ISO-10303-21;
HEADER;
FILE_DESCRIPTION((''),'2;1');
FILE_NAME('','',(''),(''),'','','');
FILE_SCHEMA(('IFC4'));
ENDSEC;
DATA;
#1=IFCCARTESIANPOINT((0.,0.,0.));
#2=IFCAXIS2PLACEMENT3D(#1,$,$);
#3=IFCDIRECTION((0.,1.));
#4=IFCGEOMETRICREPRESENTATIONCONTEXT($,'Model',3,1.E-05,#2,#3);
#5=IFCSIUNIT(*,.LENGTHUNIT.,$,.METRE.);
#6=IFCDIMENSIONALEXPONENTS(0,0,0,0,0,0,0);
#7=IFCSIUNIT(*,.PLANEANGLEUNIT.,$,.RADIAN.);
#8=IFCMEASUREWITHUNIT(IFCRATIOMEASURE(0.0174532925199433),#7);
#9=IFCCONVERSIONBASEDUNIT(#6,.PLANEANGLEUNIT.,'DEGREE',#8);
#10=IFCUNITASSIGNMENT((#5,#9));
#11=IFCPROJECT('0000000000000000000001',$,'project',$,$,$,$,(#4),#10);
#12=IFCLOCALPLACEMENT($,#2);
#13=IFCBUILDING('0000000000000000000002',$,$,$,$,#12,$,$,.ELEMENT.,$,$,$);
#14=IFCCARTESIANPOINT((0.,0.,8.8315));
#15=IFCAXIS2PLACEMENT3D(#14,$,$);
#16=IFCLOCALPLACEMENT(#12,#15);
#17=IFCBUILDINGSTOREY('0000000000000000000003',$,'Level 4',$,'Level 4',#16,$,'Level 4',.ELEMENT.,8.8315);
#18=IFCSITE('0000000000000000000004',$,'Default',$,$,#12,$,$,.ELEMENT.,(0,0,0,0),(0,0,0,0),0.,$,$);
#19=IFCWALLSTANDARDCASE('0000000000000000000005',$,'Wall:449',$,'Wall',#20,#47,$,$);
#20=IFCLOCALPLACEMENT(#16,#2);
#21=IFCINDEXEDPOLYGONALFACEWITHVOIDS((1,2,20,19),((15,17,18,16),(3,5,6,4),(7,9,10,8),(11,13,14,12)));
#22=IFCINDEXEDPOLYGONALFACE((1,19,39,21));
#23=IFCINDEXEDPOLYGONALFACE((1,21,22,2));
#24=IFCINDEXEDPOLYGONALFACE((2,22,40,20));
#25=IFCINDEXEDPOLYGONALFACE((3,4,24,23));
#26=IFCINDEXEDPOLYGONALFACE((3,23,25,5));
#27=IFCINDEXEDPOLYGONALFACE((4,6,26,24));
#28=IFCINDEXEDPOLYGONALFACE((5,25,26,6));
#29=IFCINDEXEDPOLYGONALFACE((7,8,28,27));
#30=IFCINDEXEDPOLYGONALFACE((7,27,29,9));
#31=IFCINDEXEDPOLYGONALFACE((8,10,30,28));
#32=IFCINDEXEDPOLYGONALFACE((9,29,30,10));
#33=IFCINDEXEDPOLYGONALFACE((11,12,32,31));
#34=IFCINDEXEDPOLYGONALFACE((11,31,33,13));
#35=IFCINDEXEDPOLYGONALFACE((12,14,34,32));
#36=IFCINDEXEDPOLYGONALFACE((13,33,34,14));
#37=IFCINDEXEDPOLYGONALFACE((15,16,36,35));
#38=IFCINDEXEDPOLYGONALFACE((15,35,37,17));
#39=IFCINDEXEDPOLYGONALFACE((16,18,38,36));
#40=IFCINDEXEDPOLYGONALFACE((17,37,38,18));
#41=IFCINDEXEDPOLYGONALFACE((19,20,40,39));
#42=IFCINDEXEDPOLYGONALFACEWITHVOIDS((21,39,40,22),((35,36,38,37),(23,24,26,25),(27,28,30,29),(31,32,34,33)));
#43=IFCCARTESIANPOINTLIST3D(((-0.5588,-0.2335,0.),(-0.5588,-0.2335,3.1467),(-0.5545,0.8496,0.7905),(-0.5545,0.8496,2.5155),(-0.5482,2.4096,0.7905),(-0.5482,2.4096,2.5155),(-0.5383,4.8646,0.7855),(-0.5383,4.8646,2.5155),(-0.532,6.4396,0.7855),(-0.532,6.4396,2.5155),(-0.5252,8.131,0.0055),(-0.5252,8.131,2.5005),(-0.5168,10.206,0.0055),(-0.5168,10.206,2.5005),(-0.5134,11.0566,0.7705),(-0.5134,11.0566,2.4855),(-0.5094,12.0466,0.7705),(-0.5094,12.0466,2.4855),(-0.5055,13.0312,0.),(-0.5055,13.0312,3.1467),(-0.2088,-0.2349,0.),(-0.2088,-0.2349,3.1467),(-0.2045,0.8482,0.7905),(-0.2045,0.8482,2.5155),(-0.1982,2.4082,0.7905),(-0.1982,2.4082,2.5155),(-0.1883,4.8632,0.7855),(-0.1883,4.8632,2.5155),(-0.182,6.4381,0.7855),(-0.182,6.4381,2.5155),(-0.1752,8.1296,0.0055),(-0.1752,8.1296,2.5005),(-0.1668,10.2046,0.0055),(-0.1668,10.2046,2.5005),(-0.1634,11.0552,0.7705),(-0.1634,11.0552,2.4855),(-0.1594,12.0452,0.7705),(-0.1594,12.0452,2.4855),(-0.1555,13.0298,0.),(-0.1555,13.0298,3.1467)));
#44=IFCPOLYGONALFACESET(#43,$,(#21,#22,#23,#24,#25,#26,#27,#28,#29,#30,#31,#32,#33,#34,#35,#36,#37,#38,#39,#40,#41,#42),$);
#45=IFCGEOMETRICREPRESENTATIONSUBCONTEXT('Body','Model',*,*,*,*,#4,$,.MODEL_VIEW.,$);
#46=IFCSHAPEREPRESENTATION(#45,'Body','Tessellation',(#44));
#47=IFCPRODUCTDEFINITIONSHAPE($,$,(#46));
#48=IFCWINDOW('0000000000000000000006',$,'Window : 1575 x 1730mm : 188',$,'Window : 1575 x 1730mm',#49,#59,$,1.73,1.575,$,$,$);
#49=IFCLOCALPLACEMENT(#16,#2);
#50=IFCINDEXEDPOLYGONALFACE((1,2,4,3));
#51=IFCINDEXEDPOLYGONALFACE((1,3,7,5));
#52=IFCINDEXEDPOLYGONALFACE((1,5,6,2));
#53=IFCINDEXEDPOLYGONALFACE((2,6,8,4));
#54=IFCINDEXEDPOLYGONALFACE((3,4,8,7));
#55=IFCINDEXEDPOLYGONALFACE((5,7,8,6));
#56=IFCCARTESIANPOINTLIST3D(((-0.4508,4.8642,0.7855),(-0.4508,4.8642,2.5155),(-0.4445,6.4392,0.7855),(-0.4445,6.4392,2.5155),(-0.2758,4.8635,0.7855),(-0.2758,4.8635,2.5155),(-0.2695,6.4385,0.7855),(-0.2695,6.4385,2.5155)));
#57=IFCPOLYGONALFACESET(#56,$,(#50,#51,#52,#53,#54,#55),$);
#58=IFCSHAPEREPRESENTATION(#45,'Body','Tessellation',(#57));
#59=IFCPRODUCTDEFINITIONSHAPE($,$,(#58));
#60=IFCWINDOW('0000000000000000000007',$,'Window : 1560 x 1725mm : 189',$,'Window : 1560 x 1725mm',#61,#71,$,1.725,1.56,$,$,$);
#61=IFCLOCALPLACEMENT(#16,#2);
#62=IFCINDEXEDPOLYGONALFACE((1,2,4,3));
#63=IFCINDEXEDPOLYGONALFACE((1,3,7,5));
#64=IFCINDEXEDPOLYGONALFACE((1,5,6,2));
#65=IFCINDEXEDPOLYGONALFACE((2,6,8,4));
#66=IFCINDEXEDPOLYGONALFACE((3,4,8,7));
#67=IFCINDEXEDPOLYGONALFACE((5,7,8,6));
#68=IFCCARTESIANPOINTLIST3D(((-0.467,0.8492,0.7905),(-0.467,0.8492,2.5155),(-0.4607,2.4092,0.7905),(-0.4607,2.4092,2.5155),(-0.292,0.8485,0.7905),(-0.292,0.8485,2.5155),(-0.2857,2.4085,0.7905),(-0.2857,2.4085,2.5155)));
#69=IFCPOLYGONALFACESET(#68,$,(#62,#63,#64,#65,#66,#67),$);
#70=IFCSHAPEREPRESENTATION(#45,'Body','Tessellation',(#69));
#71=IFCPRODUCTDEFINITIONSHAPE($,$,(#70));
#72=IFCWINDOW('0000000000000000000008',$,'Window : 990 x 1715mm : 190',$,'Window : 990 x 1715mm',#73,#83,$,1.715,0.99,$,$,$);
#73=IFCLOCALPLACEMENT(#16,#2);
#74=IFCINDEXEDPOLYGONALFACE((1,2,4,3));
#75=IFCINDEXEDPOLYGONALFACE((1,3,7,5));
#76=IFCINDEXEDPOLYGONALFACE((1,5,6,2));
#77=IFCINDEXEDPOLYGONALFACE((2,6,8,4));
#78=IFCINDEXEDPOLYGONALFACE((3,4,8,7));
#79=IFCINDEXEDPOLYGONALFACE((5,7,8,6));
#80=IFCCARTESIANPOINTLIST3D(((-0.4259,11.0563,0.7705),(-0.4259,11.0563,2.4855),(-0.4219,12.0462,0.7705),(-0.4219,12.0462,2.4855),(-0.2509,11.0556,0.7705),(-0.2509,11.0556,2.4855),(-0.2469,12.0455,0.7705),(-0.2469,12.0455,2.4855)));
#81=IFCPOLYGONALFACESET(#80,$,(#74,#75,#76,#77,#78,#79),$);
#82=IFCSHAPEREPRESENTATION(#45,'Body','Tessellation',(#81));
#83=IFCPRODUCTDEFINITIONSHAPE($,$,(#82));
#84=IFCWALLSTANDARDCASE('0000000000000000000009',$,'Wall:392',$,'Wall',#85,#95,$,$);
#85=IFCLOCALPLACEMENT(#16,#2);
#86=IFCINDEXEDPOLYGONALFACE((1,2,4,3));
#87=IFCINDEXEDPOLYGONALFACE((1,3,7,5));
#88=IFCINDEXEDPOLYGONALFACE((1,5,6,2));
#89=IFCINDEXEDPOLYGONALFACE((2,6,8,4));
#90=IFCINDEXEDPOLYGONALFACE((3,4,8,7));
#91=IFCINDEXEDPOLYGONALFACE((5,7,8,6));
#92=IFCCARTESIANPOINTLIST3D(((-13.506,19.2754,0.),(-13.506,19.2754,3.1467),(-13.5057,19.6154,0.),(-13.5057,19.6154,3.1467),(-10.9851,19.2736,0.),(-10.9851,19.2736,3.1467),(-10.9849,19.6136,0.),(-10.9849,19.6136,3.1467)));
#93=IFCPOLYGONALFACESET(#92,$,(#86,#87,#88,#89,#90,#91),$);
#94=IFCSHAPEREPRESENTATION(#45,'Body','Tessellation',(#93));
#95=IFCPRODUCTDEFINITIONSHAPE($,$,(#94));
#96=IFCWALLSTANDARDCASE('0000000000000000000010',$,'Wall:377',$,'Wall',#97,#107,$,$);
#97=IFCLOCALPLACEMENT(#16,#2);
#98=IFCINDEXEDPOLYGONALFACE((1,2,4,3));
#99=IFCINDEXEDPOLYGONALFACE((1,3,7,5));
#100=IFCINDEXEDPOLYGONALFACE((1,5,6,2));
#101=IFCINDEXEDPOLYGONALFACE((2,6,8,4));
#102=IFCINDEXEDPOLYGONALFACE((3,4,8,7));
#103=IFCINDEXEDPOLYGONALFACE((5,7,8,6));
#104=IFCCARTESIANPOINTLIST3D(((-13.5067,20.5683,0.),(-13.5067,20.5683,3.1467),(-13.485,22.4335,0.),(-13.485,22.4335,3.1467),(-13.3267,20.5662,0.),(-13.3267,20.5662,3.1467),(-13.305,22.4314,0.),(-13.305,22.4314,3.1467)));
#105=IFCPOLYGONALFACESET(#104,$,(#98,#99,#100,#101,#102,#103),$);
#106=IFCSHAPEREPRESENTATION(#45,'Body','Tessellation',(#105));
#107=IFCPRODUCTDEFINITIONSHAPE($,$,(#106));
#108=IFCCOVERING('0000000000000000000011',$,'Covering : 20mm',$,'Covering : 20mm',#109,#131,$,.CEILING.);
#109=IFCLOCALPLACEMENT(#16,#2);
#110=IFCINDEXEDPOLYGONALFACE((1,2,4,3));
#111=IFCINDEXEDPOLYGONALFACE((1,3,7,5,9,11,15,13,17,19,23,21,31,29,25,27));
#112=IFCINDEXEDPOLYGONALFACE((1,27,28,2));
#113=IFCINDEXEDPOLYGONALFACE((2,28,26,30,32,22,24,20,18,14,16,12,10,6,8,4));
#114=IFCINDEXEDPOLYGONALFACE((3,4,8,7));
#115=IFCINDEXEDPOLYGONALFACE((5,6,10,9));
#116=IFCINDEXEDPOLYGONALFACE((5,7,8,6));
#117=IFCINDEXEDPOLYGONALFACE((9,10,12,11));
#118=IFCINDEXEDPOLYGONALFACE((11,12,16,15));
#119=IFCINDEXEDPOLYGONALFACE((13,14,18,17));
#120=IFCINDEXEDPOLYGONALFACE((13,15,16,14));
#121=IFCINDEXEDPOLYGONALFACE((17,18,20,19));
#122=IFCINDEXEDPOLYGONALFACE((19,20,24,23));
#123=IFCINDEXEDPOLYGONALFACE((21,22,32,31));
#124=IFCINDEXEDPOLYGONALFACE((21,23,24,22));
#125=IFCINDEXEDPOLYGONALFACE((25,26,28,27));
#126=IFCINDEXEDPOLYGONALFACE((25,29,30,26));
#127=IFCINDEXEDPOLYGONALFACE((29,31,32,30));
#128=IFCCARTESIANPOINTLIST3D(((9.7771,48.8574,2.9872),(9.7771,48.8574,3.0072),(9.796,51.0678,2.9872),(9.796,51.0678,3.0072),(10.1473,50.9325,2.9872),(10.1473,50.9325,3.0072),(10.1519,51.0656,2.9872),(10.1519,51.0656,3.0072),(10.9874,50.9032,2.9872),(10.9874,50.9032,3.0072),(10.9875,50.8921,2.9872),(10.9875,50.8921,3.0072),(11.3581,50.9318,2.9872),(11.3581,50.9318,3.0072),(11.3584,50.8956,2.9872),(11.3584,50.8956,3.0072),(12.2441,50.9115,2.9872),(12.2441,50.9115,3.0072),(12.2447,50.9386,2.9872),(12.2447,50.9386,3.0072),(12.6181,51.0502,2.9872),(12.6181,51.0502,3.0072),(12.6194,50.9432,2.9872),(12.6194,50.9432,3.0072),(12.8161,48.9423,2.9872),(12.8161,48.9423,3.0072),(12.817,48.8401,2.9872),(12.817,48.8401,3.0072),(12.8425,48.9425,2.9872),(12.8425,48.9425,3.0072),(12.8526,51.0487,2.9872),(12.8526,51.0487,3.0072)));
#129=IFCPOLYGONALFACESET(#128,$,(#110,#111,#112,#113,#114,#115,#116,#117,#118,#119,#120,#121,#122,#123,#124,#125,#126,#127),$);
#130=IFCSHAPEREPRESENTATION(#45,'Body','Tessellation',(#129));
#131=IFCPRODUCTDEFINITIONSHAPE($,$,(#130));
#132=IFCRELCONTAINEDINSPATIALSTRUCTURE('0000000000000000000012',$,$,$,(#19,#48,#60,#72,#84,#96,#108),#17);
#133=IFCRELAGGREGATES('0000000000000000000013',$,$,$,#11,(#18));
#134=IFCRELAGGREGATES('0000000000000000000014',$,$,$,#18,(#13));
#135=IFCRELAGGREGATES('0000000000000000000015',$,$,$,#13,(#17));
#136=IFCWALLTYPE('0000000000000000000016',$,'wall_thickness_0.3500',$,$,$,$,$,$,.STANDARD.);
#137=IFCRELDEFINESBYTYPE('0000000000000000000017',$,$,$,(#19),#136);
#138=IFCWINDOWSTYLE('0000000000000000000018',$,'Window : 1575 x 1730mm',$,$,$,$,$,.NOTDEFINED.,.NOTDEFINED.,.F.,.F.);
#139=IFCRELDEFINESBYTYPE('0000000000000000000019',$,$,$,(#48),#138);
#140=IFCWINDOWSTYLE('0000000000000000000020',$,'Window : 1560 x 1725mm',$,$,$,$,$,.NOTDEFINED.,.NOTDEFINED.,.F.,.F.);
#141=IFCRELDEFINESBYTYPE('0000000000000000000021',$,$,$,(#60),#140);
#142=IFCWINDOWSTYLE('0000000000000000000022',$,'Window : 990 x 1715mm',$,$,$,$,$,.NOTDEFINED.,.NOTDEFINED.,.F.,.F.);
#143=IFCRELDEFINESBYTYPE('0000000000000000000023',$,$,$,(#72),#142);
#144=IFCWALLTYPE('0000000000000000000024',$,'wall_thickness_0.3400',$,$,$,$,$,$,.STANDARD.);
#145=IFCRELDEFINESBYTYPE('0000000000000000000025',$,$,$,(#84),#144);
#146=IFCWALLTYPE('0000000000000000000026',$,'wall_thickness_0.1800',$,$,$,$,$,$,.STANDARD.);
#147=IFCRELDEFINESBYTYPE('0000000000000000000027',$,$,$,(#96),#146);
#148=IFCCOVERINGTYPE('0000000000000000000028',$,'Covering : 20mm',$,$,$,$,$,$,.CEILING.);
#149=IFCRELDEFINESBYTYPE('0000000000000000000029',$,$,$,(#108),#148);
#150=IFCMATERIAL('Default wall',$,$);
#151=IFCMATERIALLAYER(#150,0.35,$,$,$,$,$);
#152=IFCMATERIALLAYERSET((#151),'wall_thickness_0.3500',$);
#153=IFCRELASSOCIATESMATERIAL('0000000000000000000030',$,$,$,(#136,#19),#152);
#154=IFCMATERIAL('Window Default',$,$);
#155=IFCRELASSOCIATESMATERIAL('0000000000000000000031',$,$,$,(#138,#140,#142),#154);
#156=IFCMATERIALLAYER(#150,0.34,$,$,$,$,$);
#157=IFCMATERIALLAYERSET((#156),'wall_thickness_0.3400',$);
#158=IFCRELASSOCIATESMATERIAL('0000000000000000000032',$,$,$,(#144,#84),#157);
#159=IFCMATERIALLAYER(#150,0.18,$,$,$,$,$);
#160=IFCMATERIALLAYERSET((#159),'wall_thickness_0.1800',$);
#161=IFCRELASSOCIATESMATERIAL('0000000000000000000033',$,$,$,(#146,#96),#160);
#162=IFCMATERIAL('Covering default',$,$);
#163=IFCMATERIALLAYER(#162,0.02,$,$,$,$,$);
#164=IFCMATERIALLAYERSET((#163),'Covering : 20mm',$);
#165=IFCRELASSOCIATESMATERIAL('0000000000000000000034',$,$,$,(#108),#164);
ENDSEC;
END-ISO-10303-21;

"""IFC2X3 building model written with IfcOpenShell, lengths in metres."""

from ifc_helpers import new_model, entity, si_unit, converted_unit, direction, frame, frame_2d, origin, origin_with_axes, origin_2d_with_axis, place, context, subcontext, project, spatial, polyline, rectangle, outline, extrude, source, transform, mapped, material, layer, layer_set, layer_usage, type_object, type_shapes, element, fill, save


model = new_model("IFC2X3")

# Units and contexts
model_context = context("Model", 3, precision=1e-05, world=origin(), true_north=direction((0.0, 1.0)))
body_context = subcontext(model_context, "Body", "Model", "MODEL_VIEW")
ifc_project = project(units=[si_unit("LENGTHUNIT", "METRE"), converted_unit("PLANEANGLEUNIT", "DEGREE", entity("IfcRatioMeasure", 0.0174532925199433), si_unit("PLANEANGLEUNIT", "RADIAN"), dimensions=[0, 0, 0, 0, 0, 0, 0])], contexts=[model_context])

# Site, building, storey
placement = place(None, origin())
site = spatial("IfcSite", under=ifc_project, at=placement, Name="Default", CompositionType="ELEMENT", RefLatitude=(0, 0, 0, 0), RefLongitude=(0, 0, 0, 0), RefElevation=0.0)
building = spatial("IfcBuilding", under=site, at=placement, CompositionType="ELEMENT")
storey_placement = place(placement, frame((0.0, 0.0, 8.8315)))
storey = spatial("IfcBuildingStorey", under=building, at=storey_placement, Name="Level 4", ObjectType="Level 4", LongName="Level 4", CompositionType="ELEMENT", Elevation=8.8315)

# Shared definitions
ifc_material_1 = material(Name="Default wall")

# Shared definitions
ifc_layer_1 = layer(ifc_material_1, 0.35)
ifc_layer_set_1 = layer_set([ifc_layer_1], Name="wall_thickness_0.3500")
ifc_layer_usage_1 = layer_usage(ifc_layer_set_1, "AXIS2", "POSITIVE", -0.175)
wall_type_1 = type_object("IfcWallType", Name="wall_thickness_0.3500", PredefinedType="STANDARD", material=ifc_layer_set_1)
ifc_material_2 = material(Name="Window Default")

# Wall, openings, windows
wall_1_placement = place(storey_placement, frame((-0.3305, 13.0305, 0.0), z_axis=(0.0, 0.0, 1.0), x_axis=(-0.004023, -0.999992, 0.0)))
wall_1 = element("IfcWallStandardCase", 1, at=wall_1_placement, inside=storey, type_object=wall_type_1, material=ifc_layer_usage_1, Name="Wall:449", ObjectType="Wall", context=body_context, shape_type="SweptSolid", body=[
    extrude(outline(polyline([(13.2649, -0.175), (13.2649, 0.175), (0.0, 0.175), (0.0, -0.175), (13.2649, -0.175)])), origin(), (0.0, 0.0, 1.0), 3.1467),
])
opening_1_placement = place(wall_1_placement, frame((2.8253, -0.175, 0.0055)))
element("IfcOpeningElement", 2, at=opening_1_placement, cuts=wall_1, ObjectType="Opening", context=body_context, shape_type="SweptSolid", body=[
    extrude(rectangle(XDim=2.075, YDim=2.495, at=frame_2d((1.2475, 1.0375), x_axis=(0.0, 1.0))), frame((0.0, 0.0, 0.0), z_axis=(0.0, 1.0, 0.0), x_axis=(0.0, 0.0, 1.0)), (0.0, 0.0, 1.0), 0.35),
])
opening_2_placement = place(wall_1_placement, frame((6.5917, -0.175, 0.7855)))
opening_2 = element("IfcOpeningElement", 3, at=opening_2_placement, cuts=wall_1, ObjectType="Opening", context=body_context, shape_type="SweptSolid", body=[
    extrude(rectangle(XDim=1.575, YDim=1.73, at=frame_2d((0.865, 0.7875), x_axis=(0.0, 1.0))), frame((0.0, 0.0, 0.0), z_axis=(0.0, 1.0, 0.0), x_axis=(0.0, 0.0, 1.0)), (0.0, 0.0, 1.0), 0.35),
])
opening_3_placement = place(wall_1_placement, frame((10.6217, -0.175, 0.7905)))
opening_3 = element("IfcOpeningElement", 4, at=opening_3_placement, cuts=wall_1, ObjectType="Opening", context=body_context, shape_type="SweptSolid", body=[
    extrude(rectangle(XDim=1.56, YDim=1.725, at=frame_2d((0.8625, 0.78), x_axis=(0.0, 1.0))), frame((0.0, 0.0, 0.0), z_axis=(0.0, 1.0, 0.0), x_axis=(0.0, 0.0, 1.0)), (0.0, 0.0, 1.0), 0.35),
])
opening_4_placement = place(wall_1_placement, frame((0.9847, -0.175, 0.7705)))
opening_4 = element("IfcOpeningElement", 5, at=opening_4_placement, cuts=wall_1, ObjectType="Opening", context=body_context, shape_type="SweptSolid", body=[
    extrude(rectangle(XDim=0.99, YDim=1.715, at=frame_2d((0.8575, 0.495), x_axis=(0.0, 1.0))), frame((0.0, 0.0, 0.0), z_axis=(0.0, 1.0, 0.0), x_axis=(0.0, 0.0, 1.0)), (0.0, 0.0, 1.0), 0.35),
])
window_style_1 = type_object("IfcWindowStyle", Name="Window : 1575 x 1730mm", ConstructionType="NOTDEFINED", OperationType="NOTDEFINED", ParameterTakesPrecedence=False, Sizeable=False, material=ifc_material_2)
shared_shape_1 = source(origin(), body_context, "Body", "SweptSolid", [
    extrude(rectangle(XDim=0.175, YDim=1.575, at=origin_2d_with_axis()), frame((0.7875, 0.175, 0.0), z_axis=(0.0, 0.0, 1.0), x_axis=(0.0, 1.0, 0.0)), (0.0, 0.0, 1.0), 1.73),
])
type_shapes(window_style_1, [shared_shape_1])
window_1_placement = place(opening_2_placement, origin())
window_1 = element("IfcWindow", 6, at=window_1_placement, inside=storey, type_object=window_style_1, Name="Window : 1575 x 1730mm : 188", ObjectType="Window : 1575 x 1730mm", OverallHeight=1.73, OverallWidth=1.575, context=body_context, shape_type="MappedRepresentation", body=[
    mapped(shared_shape_1, transform((0.0, 0.0, 0.0), scale=1.0)),
])
fill(opening_2, window_1)
window_style_2 = type_object("IfcWindowStyle", Name="Window : 1560 x 1725mm", ConstructionType="NOTDEFINED", OperationType="NOTDEFINED", ParameterTakesPrecedence=False, Sizeable=False, material=ifc_material_2)
shared_shape_2 = source(origin(), body_context, "Body", "SweptSolid", [
    extrude(rectangle(XDim=0.175, YDim=1.56, at=origin_2d_with_axis()), frame((0.78, 0.175, 0.0), z_axis=(0.0, 0.0, 1.0), x_axis=(0.0, 1.0, 0.0)), (0.0, 0.0, 1.0), 1.725),
])
type_shapes(window_style_2, [shared_shape_2])
window_2_placement = place(opening_3_placement, origin())
window_2 = element("IfcWindow", 7, at=window_2_placement, inside=storey, type_object=window_style_2, Name="Window : 1560 x 1725mm : 189", ObjectType="Window : 1560 x 1725mm", OverallHeight=1.725, OverallWidth=1.56, context=body_context, shape_type="MappedRepresentation", body=[
    mapped(shared_shape_2, transform((0.0, 0.0, 0.0), scale=1.0)),
])
fill(opening_3, window_2)
window_style_3 = type_object("IfcWindowStyle", Name="Window : 990 x 1715mm", ConstructionType="NOTDEFINED", OperationType="NOTDEFINED", ParameterTakesPrecedence=False, Sizeable=False, material=ifc_material_2)
shared_shape_3 = source(origin(), body_context, "Body", "SweptSolid", [
    extrude(rectangle(XDim=0.175, YDim=0.99, at=origin_2d_with_axis()), frame((0.495, 0.175, 0.0), z_axis=(0.0, 0.0, 1.0), x_axis=(0.0, 1.0, 0.0)), (0.0, 0.0, 1.0), 1.715),
])
type_shapes(window_style_3, [shared_shape_3])
window_3_placement = place(opening_4_placement, origin())
window_3 = element("IfcWindow", 8, at=window_3_placement, inside=storey, type_object=window_style_3, Name="Window : 990 x 1715mm : 190", ObjectType="Window : 990 x 1715mm", OverallHeight=1.715, OverallWidth=0.99, context=body_context, shape_type="MappedRepresentation", body=[
    mapped(shared_shape_3, transform((0.0, 0.0, 0.0), scale=1.0)),
])
fill(opening_4, window_3)

# Walls
ifc_layer_2 = layer(ifc_material_1, 0.34)
ifc_layer_set_2 = layer_set([ifc_layer_2], Name="wall_thickness_0.3400")
ifc_layer_usage_2 = layer_usage(ifc_layer_set_2, "AXIS2", "POSITIVE", -0.17)
wall_type_2 = type_object("IfcWallType", Name="wall_thickness_0.3400", PredefinedType="STANDARD", material=ifc_layer_set_2)
wall_2_placement = place(storey_placement, frame((-13.5058, 19.4454, 0.0), z_axis=(0.0, 0.0, 1.0), x_axis=(1.0, -0.00071, 0.0)))
element("IfcWallStandardCase", 9, at=wall_2_placement, inside=storey, type_object=wall_type_2, material=ifc_layer_usage_2, Name="Wall:392", ObjectType="Wall", context=body_context, shape_type="SweptSolid", body=[
    extrude(outline(polyline([(2.5208, -0.17), (2.5208, 0.17), (0.0, 0.17), (0.0, -0.17), (2.5208, -0.17)])), origin(), (0.0, 0.0, 1.0), 3.1467),
])
ifc_layer_3 = layer(ifc_material_1, 0.18)
ifc_layer_set_3 = layer_set([ifc_layer_3], Name="wall_thickness_0.1800")
ifc_layer_usage_3 = layer_usage(ifc_layer_set_3, "AXIS2", "POSITIVE", -0.09)
wall_type_3 = type_object("IfcWallType", Name="wall_thickness_0.1800", PredefinedType="STANDARD", material=ifc_layer_set_3)
wall_3_placement = place(storey_placement, frame((-13.395, 22.4325, 0.0), z_axis=(0.0, 0.0, 1.0), x_axis=(-0.01164, -0.999932, 0.0)))
element("IfcWallStandardCase", 10, at=wall_3_placement, inside=storey, type_object=wall_type_3, material=ifc_layer_usage_3, Name="Wall:377", ObjectType="Wall", context=body_context, shape_type="SweptSolid", body=[
    extrude(outline(polyline([(1.8653, -0.09), (1.8653, 0.09), (0.0, 0.09), (0.0, -0.09), (1.8653, -0.09)])), origin(), (0.0, 0.0, 1.0), 3.1467),
])

# Covering
ifc_material_3 = material(Name="Covering default")
ifc_layer_4 = layer(ifc_material_3, 0.02)
ifc_layer_set_4 = layer_set([ifc_layer_4], Name="Covering : 20mm")
ifc_layer_usage_4 = layer_usage(ifc_layer_set_4, "AXIS3", "POSITIVE", 0.0)
covering_type_1 = type_object("IfcCoveringType", Name="Covering : 20mm", PredefinedType="CEILING")
covering_1_placement = place(placement, frame((0.0, 0.0, 11.8187)))
element("IfcCovering", 11, at=covering_1_placement, inside=storey, type_object=covering_type_1, material=ifc_layer_usage_4, Name="Covering : 20mm", ObjectType="Covering : 20mm", PredefinedType="CEILING", context=body_context, shape_type="SweptSolid", body=[
    extrude(outline(polyline([(9.796, 51.0678), (10.1519, 51.0656), (10.1473, 50.9325), (10.9874, 50.9032), (10.9875, 50.8921), (11.3584, 50.8956), (11.3581, 50.9318), (12.2441, 50.9115), (12.2447, 50.9386), (12.6194, 50.9432), (12.6181, 51.0502), (12.8526, 51.0487), (12.8425, 48.9425), (12.8161, 48.9423), (12.817, 48.8401), (9.7771, 48.8574), (9.796, 51.0678)])), origin_with_axes(), (0.0, 0.0, 1.0), 0.02),
])

save(model, "model.ifc")
